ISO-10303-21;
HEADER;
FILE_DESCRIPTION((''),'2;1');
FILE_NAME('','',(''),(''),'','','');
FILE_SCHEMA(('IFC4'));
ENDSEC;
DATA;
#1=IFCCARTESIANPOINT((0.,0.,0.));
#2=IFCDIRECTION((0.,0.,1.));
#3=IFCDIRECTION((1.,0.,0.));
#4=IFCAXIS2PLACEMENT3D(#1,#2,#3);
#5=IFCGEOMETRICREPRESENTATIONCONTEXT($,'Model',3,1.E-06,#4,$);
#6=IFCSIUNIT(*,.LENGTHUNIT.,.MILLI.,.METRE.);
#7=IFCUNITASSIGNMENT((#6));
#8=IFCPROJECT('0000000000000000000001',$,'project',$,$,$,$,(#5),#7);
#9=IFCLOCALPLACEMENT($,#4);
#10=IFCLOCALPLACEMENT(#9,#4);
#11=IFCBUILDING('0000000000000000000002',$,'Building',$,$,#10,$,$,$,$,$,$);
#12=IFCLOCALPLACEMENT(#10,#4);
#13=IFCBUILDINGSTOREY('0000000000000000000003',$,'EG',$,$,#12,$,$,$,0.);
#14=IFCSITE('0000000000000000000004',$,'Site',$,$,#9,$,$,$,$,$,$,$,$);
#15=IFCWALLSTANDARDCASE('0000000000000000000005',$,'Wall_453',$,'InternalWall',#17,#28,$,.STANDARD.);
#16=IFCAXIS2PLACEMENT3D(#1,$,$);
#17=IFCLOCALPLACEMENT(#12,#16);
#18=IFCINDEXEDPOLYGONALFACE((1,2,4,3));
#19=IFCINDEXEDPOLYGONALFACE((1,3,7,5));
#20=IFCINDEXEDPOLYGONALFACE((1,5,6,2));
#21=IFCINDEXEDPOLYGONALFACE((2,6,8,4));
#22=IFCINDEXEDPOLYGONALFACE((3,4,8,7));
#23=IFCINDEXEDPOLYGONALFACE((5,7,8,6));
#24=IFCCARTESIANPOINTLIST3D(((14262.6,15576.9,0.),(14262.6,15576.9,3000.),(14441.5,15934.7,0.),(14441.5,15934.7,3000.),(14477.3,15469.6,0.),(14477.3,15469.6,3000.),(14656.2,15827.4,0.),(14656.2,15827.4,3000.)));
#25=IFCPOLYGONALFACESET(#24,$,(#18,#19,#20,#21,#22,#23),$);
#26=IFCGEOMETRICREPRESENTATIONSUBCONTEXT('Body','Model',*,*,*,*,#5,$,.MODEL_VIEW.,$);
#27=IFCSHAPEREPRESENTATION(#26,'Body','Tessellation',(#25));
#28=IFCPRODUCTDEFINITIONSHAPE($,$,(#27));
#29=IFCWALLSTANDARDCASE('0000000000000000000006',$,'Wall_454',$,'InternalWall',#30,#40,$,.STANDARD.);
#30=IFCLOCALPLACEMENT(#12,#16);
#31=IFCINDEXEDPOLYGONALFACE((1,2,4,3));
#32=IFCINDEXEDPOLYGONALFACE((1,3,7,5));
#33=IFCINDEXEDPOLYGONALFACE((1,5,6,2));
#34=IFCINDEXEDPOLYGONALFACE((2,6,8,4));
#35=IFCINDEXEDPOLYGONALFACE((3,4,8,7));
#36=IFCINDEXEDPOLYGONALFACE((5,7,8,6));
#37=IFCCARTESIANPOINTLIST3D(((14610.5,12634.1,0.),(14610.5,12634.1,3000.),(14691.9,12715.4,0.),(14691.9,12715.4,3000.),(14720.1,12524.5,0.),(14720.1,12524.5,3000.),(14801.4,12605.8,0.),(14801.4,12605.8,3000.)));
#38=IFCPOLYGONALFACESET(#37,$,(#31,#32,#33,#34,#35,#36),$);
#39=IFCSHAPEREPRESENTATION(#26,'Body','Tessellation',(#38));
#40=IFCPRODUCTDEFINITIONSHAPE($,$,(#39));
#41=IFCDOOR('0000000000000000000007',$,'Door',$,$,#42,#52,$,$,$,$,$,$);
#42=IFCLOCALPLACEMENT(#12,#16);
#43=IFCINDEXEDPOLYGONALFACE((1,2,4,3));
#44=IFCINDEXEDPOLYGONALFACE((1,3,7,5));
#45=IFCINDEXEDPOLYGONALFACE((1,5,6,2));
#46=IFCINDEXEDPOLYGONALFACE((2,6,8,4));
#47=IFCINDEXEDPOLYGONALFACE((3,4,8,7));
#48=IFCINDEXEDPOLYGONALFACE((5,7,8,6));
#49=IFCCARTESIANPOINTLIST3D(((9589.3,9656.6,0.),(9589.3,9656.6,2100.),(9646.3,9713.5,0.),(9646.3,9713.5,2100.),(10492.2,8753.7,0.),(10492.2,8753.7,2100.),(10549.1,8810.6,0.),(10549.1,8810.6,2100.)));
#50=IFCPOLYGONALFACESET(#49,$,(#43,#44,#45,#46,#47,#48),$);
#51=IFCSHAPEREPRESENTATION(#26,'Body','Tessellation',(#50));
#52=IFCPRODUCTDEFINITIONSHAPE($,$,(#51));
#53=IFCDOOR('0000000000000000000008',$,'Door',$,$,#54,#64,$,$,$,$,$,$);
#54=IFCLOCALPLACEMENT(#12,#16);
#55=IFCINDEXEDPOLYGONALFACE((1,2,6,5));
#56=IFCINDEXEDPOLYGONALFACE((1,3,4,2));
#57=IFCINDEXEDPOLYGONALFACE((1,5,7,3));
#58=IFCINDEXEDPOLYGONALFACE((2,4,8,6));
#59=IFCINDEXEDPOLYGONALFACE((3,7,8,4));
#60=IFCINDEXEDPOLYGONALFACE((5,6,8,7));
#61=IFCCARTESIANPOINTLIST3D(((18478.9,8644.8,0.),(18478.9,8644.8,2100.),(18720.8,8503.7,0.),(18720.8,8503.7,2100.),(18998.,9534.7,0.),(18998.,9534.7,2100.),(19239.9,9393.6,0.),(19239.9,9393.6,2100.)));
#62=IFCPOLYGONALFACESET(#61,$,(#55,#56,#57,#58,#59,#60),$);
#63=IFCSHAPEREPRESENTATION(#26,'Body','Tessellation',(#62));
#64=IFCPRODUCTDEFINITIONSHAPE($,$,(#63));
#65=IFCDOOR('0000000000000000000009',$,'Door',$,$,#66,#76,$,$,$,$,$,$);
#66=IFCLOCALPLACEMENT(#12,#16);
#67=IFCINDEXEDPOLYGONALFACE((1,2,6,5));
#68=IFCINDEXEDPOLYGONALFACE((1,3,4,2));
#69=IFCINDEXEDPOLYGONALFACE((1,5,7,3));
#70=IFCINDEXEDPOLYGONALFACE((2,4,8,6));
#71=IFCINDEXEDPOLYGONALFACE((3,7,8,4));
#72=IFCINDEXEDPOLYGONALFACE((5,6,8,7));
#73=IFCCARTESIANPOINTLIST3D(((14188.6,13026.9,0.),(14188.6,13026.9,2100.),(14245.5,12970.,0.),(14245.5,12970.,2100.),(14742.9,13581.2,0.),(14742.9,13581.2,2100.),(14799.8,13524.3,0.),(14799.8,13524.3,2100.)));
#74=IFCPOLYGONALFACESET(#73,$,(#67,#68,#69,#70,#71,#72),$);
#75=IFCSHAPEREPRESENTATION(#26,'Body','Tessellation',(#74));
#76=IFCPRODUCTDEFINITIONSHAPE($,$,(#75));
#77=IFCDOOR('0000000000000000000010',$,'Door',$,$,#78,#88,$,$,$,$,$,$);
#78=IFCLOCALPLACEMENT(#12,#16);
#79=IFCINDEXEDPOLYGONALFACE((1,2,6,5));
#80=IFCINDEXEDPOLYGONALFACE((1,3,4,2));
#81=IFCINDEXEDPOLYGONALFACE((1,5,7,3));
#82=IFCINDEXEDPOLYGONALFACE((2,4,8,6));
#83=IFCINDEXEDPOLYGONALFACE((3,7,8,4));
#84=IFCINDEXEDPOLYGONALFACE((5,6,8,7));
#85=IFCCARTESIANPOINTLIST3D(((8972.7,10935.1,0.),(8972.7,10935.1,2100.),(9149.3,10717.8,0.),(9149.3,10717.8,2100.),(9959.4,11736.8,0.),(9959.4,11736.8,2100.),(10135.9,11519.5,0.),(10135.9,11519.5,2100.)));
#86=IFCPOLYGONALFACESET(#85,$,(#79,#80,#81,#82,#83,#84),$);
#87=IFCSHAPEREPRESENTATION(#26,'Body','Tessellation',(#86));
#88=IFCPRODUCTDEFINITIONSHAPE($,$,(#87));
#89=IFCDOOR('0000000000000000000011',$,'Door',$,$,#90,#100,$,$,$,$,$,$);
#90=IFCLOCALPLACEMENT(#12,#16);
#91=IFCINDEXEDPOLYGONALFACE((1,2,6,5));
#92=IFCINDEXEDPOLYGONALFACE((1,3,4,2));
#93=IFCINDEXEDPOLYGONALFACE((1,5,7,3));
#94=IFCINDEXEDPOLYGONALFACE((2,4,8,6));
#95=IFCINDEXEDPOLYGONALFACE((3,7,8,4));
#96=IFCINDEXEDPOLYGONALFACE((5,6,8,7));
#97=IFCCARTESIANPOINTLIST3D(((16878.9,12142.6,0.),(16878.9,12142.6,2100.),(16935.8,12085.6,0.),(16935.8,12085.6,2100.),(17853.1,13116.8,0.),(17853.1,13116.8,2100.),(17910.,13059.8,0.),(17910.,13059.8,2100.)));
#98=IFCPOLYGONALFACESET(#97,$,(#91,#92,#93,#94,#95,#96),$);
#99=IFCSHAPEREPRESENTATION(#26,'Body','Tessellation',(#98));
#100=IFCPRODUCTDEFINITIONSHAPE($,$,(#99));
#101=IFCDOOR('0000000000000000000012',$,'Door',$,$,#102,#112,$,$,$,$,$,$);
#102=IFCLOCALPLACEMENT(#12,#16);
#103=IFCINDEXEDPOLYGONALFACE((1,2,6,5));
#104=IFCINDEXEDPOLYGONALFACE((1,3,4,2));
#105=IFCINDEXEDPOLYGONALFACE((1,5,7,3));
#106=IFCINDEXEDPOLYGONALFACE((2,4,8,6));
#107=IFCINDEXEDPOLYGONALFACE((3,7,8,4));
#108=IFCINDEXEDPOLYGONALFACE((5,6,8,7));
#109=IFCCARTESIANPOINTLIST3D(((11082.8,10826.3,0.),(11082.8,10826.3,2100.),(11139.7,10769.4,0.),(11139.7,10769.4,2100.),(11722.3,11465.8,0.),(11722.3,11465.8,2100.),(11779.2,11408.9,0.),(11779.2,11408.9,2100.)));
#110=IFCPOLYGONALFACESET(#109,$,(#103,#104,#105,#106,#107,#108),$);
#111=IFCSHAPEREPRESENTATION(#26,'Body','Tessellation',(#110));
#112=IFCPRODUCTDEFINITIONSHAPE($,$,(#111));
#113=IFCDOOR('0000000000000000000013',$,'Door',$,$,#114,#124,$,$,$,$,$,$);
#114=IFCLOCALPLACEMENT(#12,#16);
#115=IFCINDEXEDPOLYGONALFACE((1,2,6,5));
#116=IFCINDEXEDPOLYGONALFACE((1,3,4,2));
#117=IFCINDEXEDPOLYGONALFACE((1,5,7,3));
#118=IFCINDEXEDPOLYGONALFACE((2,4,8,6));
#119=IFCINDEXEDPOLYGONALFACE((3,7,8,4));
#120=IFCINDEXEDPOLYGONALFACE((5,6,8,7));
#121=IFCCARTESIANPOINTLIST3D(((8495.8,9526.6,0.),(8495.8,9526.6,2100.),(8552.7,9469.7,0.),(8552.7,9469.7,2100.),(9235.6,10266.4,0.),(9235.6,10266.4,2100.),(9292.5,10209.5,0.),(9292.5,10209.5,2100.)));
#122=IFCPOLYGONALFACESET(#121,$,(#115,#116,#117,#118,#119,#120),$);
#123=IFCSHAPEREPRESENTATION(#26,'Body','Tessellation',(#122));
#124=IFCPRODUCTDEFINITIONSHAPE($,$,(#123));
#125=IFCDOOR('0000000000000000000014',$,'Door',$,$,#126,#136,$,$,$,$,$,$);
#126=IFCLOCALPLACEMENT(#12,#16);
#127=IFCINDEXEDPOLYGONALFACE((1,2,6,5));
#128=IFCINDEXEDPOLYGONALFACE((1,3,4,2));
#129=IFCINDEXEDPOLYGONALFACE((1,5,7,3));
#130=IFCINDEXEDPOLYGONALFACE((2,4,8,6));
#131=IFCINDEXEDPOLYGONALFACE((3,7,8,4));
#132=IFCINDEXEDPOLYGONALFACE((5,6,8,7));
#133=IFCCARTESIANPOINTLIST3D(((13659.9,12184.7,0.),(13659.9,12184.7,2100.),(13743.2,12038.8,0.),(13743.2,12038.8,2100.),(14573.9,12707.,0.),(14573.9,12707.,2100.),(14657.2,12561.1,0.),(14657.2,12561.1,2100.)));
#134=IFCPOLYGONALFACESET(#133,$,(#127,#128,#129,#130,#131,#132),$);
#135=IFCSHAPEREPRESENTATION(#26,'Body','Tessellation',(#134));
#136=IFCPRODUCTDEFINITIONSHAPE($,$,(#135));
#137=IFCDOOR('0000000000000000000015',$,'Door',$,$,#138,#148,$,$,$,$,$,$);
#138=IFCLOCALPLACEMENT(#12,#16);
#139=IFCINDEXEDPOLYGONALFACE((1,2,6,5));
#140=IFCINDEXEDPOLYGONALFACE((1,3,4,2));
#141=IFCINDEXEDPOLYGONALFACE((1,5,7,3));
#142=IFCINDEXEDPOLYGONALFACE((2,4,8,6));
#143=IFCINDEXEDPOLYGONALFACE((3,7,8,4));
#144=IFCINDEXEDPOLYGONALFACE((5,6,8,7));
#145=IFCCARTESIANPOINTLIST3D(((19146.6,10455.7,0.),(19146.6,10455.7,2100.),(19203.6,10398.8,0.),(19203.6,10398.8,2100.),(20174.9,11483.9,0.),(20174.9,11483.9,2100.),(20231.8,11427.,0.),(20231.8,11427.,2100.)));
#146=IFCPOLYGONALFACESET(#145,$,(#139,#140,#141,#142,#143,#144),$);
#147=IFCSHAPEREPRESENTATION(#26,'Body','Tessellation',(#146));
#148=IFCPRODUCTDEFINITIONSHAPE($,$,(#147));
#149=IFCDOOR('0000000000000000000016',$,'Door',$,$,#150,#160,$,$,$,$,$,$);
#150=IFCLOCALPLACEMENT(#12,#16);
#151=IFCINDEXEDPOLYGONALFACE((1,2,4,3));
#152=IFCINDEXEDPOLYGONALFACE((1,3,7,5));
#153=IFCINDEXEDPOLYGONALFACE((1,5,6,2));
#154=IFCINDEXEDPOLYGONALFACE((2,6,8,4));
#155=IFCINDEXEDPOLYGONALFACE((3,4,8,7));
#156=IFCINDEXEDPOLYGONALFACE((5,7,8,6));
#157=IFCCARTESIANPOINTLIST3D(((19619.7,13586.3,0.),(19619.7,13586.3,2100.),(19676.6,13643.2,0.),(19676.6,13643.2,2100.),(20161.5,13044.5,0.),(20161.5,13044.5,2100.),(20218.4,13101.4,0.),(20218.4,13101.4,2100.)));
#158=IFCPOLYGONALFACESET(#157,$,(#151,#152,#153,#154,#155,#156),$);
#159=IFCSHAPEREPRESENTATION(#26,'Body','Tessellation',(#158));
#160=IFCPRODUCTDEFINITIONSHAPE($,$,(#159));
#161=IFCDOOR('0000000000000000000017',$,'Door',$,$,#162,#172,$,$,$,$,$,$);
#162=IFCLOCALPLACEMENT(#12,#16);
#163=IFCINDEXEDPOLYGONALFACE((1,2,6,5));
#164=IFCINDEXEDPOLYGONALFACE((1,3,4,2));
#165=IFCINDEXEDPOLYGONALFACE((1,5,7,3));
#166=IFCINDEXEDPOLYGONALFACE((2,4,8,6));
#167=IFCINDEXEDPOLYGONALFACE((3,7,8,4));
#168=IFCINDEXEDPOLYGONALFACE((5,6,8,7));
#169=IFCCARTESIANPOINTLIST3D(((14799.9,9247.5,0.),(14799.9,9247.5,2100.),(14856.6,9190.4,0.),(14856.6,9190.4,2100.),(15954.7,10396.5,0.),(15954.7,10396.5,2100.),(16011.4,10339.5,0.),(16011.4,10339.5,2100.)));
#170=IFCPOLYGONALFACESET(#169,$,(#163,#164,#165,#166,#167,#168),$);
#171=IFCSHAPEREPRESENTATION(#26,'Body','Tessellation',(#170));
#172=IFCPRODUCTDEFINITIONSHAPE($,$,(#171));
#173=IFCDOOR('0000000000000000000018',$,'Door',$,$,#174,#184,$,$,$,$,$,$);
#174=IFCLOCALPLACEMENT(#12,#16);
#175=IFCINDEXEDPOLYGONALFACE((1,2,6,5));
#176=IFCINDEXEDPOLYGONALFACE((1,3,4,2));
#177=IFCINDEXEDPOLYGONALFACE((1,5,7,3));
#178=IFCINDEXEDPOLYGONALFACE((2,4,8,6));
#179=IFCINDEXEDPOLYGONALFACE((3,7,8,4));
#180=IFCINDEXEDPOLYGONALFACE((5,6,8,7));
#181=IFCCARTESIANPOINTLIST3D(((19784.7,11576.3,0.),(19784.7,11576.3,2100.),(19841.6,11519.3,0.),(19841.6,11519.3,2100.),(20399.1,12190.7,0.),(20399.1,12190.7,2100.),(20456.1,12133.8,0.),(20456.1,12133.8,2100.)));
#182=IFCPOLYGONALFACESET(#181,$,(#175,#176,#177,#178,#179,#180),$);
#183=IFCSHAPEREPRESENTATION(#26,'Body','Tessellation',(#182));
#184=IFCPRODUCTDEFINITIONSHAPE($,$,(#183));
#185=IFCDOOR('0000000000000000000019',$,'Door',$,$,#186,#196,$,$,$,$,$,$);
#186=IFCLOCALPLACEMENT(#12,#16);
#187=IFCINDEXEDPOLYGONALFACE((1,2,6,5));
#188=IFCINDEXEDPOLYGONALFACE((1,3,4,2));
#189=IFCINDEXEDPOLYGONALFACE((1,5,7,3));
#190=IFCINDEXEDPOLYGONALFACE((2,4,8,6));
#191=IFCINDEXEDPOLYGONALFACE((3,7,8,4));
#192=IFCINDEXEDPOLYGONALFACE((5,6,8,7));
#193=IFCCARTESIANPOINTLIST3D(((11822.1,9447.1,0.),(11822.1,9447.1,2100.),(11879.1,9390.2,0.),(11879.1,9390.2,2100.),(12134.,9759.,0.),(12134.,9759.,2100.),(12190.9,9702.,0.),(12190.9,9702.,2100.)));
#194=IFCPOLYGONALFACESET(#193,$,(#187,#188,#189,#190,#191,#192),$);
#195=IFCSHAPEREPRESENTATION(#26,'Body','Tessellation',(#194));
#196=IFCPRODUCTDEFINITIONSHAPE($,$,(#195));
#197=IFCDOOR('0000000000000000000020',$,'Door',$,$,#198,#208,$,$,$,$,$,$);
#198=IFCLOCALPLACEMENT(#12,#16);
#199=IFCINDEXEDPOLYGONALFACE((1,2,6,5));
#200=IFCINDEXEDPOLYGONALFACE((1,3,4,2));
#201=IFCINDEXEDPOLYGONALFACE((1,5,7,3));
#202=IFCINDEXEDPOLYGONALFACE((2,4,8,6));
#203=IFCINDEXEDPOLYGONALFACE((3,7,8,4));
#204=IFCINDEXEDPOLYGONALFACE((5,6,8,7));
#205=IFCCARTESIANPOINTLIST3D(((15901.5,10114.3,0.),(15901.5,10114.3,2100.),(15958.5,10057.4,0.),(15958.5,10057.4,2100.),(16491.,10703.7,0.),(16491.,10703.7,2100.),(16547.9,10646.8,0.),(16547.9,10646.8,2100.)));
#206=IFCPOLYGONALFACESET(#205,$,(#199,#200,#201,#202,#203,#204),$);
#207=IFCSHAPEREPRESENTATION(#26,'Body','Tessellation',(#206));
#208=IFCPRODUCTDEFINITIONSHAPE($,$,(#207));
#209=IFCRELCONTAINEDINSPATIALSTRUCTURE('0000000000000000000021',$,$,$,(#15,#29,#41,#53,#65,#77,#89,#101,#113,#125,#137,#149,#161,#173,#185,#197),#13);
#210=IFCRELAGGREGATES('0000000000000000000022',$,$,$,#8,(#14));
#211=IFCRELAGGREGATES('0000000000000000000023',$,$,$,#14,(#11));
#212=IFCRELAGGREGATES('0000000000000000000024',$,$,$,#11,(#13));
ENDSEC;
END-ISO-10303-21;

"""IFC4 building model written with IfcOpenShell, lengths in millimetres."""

from ifc_helpers import new_model, si_unit, frame, origin_with_axes, place, context, subcontext, project, spatial, rectangle, extrude, element, save


model = new_model("IFC4")

# Units and contexts
model_context = context("Model", 3, precision=1e-06, world=origin_with_axes())
body_context = subcontext(model_context, "Body", "Model", "MODEL_VIEW")
ifc_project = project(units=[si_unit("LENGTHUNIT", "METRE", prefix="MILLI")], contexts=[model_context])

# Site, building, storey
site_placement = place(None, origin_with_axes())
site = spatial("IfcSite", under=ifc_project, at=site_placement, Name="Site")
building_placement = place(site_placement, origin_with_axes())
building = spatial("IfcBuilding", under=site, at=building_placement, Name="Building")
storey_placement = place(building_placement, origin_with_axes())
storey = spatial("IfcBuildingStorey", under=building, at=storey_placement, Name="EG", Elevation=0.0)

# Walls
wall_1_placement = place(storey_placement, origin_with_axes())
element("IfcWallStandardCase", 1, at=wall_1_placement, inside=storey, Name="Wall_453", ObjectType="InternalWall", PredefinedType="STANDARD", context=body_context, shape_type="SweptSolid", body=[
    extrude(rectangle(XDim=400.0, YDim=240.0), frame((14459.4, 15702.1, 0.0), z_axis=(0.0, 0.0, 1.0), x_axis=(0.447214, 0.894427, 0.0)), (0.0, 0.0, 1.0), 3000.0),
])
wall_2_placement = place(storey_placement, origin_with_axes())
element("IfcWallStandardCase", 2, at=wall_2_placement, inside=storey, Name="Wall_454", ObjectType="InternalWall", PredefinedType="STANDARD", context=body_context, shape_type="SweptSolid", body=[
    extrude(rectangle(XDim=155.0, YDim=115.0), frame((14706.0, 12619.9, 0.0), z_axis=(0.0, 0.0, 1.0), x_axis=(0.707107, -0.707107, 0.0)), (0.0, 0.0, 1.0), 3000.0),
])

# Doors
door_1_placement = place(storey_placement, origin_with_axes())
element("IfcDoor", 3, at=door_1_placement, inside=storey, Name="Door", context=body_context, shape_type="SweptSolid", body=[
    extrude(rectangle(XDim=1276.8, YDim=80.5), frame((10069.2, 9233.6, 0.0), z_axis=(0.0, 0.0, 1.0), x_axis=(-0.707107, 0.707107, 0.0)), (0.0, 0.0, 1.0), 2100.0),
])
door_2_placement = place(storey_placement, origin_with_axes())
element("IfcDoor", 4, at=door_2_placement, inside=storey, Name="Door", context=body_context, shape_type="SweptSolid", body=[
    extrude(rectangle(XDim=1030.2, YDim=280.0), frame((18859.4, 9019.2, 0.0), z_axis=(0.0, 0.0, 1.0), x_axis=(0.503871, 0.863779, 0.0)), (0.0, 0.0, 1.0), 2100.0),
])
door_3_placement = place(storey_placement, origin_with_axes())
element("IfcDoor", 5, at=door_3_placement, inside=storey, Name="Door", context=body_context, shape_type="SweptSolid", body=[
    extrude(rectangle(XDim=783.9, YDim=80.5), frame((14494.2, 13275.6, 0.0), z_axis=(0.0, 0.0, 1.0), x_axis=(-0.707107, -0.707107, 0.0)), (0.0, 0.0, 1.0), 2100.0),
])
door_4_placement = place(storey_placement, origin_with_axes())
element("IfcDoor", 6, at=door_4_placement, inside=storey, Name="Door", context=body_context, shape_type="SweptSolid", body=[
    extrude(rectangle(XDim=1271.3, YDim=280.0), frame((9554.3, 11227.3, 0.0), z_axis=(0.0, 0.0, 1.0), x_axis=(-0.776114, -0.630593, 0.0)), (0.0, 0.0, 1.0), 2100.0),
])
door_5_placement = place(storey_placement, origin_with_axes())
element("IfcDoor", 7, at=door_5_placement, inside=storey, Name="Door", context=body_context, shape_type="SweptSolid", body=[
    extrude(rectangle(XDim=1377.7, YDim=80.5), frame((17394.4, 12601.2, 0.0), z_axis=(0.0, 0.0, 1.0), x_axis=(-0.707107, -0.707107, 0.0)), (0.0, 0.0, 1.0), 2100.0),
])
door_6_placement = place(storey_placement, origin_with_axes())
element("IfcDoor", 8, at=door_6_placement, inside=storey, Name="Door", context=body_context, shape_type="SweptSolid", body=[
    extrude(rectangle(XDim=904.4, YDim=80.5), frame((11431.0, 11117.6, 0.0), z_axis=(0.0, 0.0, 1.0), x_axis=(-0.707107, -0.707107, 0.0)), (0.0, 0.0, 1.0), 2100.0),
])
door_7_placement = place(storey_placement, origin_with_axes())
element("IfcDoor", 9, at=door_7_placement, inside=storey, Name="Door", context=body_context, shape_type="SweptSolid", body=[
    extrude(rectangle(XDim=1046.3, YDim=80.5), frame((8894.2, 9868.0, 0.0), z_axis=(0.0, 0.0, 1.0), x_axis=(0.707107, 0.707107, 0.0)), (0.0, 0.0, 1.0), 2100.0),
])
door_8_placement = place(storey_placement, origin_with_axes())
element("IfcDoor", 10, at=door_8_placement, inside=storey, Name="Door", context=body_context, shape_type="SweptSolid", body=[
    extrude(rectangle(XDim=1052.7, YDim=168.0), frame((14158.6, 12372.9, 0.0), z_axis=(0.0, 0.0, 1.0), x_axis=(0.868243, 0.496139, 0.0)), (0.0, 0.0, 1.0), 2100.0),
])
door_9_placement = place(storey_placement, origin_with_axes())
element("IfcDoor", 11, at=door_9_placement, inside=storey, Name="Door", context=body_context, shape_type="SweptSolid", body=[
    extrude(rectangle(XDim=1454.1, YDim=80.5), frame((19689.2, 10941.4, 0.0), z_axis=(0.0, 0.0, 1.0), x_axis=(-0.707107, -0.707107, 0.0)), (0.0, 0.0, 1.0), 2100.0),
])
door_10_placement = place(storey_placement, origin_with_axes())
element("IfcDoor", 12, at=door_10_placement, inside=storey, Name="Door", context=body_context, shape_type="SweptSolid", body=[
    extrude(rectangle(XDim=766.2, YDim=80.5), frame((19919.1, 13343.8, 0.0), z_axis=(0.0, 0.0, 1.0), x_axis=(0.707107, -0.707107, 0.0)), (0.0, 0.0, 1.0), 2100.0),
])
door_11_placement = place(storey_placement, origin_with_axes())
element("IfcDoor", 13, at=door_11_placement, inside=storey, Name="Door", context=body_context, shape_type="SweptSolid", body=[
    extrude(rectangle(XDim=1629.1, YDim=80.5), frame((15405.7, 9793.5, 0.0), z_axis=(0.0, 0.0, 1.0), x_axis=(-0.708868, -0.705341, 0.0)), (0.0, 0.0, 1.0), 2100.0),
])
door_12_placement = place(storey_placement, origin_with_axes())
element("IfcDoor", 14, at=door_12_placement, inside=storey, Name="Door", context=body_context, shape_type="SweptSolid", body=[
    extrude(rectangle(XDim=868.9, YDim=80.5), frame((20120.4, 11855.0, 0.0), z_axis=(0.0, 0.0, 1.0), x_axis=(0.707107, 0.707107, 0.0)), (0.0, 0.0, 1.0), 2100.0),
])
door_13_placement = place(storey_placement, origin_with_axes())
element("IfcDoor", 15, at=door_13_placement, inside=storey, Name="Door", context=body_context, shape_type="SweptSolid", body=[
    extrude(rectangle(XDim=441.0, YDim=80.5), frame((12006.5, 9574.6, 0.0), z_axis=(0.0, 0.0, 1.0), x_axis=(-0.707107, -0.707107, 0.0)), (0.0, 0.0, 1.0), 2100.0),
])
door_14_placement = place(storey_placement, origin_with_axes())
element("IfcDoor", 16, at=door_14_placement, inside=storey, Name="Door", context=body_context, shape_type="SweptSolid", body=[
    extrude(rectangle(XDim=833.6, YDim=80.5), frame((16224.7, 10380.5, 0.0), z_axis=(0.0, 0.0, 1.0), x_axis=(-0.707107, -0.707107, 0.0)), (0.0, 0.0, 1.0), 2100.0),
])

save(model, "model.ifc")
